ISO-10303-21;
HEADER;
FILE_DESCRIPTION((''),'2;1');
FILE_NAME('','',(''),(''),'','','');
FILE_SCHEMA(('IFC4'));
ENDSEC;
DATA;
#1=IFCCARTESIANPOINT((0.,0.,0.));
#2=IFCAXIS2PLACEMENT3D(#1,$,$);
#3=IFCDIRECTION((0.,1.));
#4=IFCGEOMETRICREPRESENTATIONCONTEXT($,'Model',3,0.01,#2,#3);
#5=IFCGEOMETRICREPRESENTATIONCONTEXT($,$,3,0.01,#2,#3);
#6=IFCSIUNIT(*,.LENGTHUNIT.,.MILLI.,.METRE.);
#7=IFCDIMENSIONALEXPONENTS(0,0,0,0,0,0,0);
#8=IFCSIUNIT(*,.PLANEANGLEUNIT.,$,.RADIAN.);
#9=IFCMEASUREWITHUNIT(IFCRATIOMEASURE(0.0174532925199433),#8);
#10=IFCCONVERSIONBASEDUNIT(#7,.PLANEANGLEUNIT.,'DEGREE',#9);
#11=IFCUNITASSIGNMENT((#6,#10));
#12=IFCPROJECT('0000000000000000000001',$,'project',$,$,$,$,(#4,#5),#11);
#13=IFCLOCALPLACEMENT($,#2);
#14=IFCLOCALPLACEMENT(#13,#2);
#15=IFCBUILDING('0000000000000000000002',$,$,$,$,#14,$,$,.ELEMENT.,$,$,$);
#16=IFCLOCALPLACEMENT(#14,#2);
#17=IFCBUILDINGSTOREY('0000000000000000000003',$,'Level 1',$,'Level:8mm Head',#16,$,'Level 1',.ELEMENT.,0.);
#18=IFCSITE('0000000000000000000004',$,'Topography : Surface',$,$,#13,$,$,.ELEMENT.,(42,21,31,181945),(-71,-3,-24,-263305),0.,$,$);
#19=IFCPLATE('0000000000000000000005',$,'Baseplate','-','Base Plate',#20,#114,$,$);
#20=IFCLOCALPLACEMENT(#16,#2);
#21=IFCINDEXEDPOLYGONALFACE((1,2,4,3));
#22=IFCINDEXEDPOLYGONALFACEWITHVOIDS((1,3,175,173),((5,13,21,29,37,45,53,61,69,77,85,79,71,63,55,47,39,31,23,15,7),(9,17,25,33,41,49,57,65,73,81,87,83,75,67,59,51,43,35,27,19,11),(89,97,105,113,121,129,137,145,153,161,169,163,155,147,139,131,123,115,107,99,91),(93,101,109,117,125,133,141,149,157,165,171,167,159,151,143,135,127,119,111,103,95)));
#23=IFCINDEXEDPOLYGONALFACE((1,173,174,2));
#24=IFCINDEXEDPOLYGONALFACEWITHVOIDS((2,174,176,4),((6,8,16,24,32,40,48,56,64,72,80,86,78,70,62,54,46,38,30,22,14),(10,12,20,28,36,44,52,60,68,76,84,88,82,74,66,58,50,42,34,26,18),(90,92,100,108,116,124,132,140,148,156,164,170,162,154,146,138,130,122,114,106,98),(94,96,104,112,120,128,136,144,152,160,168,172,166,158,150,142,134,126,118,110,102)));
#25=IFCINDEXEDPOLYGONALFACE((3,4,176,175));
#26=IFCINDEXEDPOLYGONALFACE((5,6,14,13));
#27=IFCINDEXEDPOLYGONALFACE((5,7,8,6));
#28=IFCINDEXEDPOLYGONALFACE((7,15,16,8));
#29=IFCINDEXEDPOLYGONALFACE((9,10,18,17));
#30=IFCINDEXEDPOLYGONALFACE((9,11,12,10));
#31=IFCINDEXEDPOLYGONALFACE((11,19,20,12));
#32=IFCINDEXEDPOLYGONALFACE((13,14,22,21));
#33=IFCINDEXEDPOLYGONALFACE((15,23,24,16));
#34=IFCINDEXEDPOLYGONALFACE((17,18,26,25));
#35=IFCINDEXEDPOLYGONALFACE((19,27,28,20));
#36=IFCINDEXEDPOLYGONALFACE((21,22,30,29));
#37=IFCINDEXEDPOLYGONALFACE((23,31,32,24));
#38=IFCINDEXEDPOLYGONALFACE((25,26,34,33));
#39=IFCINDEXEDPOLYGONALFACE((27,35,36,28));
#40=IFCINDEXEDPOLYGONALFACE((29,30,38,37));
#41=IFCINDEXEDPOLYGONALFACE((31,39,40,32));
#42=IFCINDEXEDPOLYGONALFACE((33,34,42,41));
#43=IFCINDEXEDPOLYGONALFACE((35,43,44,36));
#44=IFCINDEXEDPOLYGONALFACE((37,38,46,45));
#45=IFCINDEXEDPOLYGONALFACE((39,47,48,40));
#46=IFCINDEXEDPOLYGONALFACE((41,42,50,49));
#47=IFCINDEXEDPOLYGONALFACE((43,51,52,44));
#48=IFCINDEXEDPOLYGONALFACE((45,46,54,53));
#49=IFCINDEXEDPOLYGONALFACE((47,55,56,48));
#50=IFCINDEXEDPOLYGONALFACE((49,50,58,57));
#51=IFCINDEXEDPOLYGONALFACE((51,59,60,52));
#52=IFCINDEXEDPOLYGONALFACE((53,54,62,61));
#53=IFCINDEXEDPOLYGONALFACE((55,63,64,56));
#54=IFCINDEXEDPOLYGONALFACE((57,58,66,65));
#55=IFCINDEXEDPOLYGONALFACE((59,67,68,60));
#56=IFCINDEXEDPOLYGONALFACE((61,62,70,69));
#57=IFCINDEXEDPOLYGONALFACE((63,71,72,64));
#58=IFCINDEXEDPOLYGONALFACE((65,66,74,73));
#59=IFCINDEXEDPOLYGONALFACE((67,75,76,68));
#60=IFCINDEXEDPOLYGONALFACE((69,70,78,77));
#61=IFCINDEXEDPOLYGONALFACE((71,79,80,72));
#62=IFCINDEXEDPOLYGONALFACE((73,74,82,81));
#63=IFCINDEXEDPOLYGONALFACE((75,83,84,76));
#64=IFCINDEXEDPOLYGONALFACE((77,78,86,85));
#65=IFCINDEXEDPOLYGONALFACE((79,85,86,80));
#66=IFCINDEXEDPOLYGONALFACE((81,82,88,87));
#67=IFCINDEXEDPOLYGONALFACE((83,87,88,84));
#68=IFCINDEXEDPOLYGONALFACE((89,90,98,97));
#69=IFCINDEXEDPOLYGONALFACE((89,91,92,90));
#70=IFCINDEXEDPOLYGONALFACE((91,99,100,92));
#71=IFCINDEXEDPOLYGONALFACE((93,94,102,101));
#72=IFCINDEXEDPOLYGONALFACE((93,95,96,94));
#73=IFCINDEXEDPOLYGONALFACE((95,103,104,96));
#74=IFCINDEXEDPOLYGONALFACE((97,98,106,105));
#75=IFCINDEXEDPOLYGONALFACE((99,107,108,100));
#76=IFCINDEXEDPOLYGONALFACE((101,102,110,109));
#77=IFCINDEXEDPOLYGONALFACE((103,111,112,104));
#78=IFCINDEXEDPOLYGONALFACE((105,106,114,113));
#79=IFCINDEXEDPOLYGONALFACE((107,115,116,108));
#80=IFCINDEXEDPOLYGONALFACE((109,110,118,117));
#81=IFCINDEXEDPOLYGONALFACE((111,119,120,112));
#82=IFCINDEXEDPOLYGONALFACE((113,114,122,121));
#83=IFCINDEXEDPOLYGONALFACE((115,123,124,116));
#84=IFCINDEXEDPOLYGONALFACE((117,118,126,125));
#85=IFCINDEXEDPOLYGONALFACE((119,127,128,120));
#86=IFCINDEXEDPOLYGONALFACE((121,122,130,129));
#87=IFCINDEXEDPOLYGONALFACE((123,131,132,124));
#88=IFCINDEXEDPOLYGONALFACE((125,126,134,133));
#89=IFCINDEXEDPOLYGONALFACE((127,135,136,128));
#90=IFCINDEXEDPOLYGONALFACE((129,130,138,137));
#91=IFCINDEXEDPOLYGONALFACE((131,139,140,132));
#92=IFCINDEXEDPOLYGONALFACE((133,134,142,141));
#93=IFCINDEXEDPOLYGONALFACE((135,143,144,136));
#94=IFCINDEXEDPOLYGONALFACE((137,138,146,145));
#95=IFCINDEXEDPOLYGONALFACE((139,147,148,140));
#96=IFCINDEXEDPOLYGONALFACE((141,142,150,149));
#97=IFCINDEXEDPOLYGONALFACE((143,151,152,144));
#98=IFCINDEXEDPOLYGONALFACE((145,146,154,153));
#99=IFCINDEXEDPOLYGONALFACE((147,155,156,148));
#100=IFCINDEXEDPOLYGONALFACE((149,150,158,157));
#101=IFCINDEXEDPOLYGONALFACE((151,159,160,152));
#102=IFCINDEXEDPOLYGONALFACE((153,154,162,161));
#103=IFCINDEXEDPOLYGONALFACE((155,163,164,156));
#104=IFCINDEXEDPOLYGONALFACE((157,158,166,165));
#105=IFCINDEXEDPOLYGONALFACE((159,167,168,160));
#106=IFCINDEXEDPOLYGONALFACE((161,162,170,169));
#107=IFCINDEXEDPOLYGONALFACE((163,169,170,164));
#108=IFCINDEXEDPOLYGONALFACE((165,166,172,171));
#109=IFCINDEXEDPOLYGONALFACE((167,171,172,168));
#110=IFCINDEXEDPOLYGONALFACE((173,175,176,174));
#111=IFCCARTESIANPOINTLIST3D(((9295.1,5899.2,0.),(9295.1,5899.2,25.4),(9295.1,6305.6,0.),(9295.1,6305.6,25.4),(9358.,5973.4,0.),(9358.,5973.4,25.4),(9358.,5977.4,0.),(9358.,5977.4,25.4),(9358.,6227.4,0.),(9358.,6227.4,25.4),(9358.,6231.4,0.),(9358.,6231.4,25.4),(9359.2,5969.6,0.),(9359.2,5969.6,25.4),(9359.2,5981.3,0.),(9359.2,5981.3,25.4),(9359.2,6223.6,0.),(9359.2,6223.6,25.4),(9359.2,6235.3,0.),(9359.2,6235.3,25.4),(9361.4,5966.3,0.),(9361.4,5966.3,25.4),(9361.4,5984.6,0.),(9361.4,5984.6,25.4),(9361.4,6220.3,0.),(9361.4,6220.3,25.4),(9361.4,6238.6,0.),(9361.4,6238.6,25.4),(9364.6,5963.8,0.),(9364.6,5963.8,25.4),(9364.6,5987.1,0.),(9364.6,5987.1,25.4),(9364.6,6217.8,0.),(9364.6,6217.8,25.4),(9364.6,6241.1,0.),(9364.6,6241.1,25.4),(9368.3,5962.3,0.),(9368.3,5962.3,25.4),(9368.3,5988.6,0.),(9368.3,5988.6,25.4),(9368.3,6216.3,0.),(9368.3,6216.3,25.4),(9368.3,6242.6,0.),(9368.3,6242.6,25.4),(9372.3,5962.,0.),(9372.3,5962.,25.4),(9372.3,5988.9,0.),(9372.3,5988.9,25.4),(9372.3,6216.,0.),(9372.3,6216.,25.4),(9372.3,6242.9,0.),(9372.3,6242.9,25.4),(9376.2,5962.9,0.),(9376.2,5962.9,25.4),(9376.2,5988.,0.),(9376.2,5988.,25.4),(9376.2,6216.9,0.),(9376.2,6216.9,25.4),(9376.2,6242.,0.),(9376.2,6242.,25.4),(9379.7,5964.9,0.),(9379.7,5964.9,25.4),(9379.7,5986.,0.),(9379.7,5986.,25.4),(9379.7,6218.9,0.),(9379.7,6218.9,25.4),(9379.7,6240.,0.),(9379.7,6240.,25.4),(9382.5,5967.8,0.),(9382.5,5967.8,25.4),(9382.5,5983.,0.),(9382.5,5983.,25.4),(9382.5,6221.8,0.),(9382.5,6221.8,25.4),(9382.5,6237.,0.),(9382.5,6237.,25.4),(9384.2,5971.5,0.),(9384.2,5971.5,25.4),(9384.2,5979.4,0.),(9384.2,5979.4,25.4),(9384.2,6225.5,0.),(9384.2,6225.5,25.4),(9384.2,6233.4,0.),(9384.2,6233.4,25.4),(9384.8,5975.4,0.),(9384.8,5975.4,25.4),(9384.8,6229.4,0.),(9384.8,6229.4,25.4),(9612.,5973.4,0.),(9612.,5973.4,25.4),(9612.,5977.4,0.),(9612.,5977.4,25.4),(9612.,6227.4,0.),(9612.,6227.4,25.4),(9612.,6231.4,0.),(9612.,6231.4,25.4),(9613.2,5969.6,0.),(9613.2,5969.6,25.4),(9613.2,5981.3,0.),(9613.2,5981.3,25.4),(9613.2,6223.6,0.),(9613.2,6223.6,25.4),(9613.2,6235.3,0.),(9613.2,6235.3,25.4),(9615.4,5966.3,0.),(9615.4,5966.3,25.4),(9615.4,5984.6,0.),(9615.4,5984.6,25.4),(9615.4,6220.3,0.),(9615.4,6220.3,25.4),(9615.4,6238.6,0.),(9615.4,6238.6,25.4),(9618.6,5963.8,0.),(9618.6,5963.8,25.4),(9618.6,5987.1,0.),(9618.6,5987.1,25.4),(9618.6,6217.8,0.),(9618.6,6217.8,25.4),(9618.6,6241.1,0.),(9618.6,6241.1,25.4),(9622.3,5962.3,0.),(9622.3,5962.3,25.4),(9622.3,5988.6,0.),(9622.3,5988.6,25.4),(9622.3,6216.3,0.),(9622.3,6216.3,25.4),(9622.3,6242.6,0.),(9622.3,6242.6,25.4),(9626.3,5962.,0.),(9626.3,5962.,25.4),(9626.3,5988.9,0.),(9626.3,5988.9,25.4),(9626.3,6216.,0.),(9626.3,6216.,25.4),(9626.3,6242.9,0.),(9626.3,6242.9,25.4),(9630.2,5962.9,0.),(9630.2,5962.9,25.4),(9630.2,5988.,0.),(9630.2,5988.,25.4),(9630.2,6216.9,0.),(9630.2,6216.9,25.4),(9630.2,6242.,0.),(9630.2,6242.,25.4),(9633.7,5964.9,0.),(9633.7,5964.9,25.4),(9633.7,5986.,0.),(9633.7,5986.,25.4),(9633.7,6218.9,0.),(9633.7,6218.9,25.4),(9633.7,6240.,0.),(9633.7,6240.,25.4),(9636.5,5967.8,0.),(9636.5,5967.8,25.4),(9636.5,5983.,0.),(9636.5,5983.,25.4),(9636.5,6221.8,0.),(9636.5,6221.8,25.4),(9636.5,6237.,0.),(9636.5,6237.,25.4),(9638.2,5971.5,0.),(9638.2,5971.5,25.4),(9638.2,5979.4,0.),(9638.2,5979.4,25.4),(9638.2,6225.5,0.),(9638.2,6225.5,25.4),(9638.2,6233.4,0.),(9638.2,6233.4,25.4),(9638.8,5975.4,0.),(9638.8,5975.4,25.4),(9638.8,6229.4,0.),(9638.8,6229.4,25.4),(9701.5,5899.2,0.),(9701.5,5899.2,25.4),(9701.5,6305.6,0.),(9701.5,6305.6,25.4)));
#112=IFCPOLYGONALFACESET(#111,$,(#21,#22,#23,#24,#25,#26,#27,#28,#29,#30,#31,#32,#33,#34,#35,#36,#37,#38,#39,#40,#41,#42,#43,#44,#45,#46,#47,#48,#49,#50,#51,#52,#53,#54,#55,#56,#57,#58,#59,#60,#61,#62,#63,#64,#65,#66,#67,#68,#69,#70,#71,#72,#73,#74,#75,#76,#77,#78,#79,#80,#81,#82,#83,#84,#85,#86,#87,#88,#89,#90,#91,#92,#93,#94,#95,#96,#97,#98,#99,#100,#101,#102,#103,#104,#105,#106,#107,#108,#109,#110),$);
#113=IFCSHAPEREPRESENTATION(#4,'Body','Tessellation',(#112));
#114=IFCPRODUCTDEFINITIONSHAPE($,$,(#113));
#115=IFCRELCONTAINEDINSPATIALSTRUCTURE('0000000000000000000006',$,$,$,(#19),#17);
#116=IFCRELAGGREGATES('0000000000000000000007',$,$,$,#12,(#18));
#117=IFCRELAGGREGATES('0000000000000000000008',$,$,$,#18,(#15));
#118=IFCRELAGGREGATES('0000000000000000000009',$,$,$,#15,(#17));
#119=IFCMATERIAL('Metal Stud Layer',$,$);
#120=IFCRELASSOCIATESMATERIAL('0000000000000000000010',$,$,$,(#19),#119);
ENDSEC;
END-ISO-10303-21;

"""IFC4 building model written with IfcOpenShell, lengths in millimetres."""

from ifc_helpers import new_model, entity, si_unit, converted_unit, direction, frame, frame_2d, origin, origin_with_axes, place, context, project, spatial, polyline, circle, outline, extrude, material, element, save


model = new_model("IFC4")

# Units and contexts
model_context = context("Model", 3, precision=0.01, world=origin(), true_north=direction((0.0, 1.0)))
context_of_model = context(None, 3, precision=0.01, world=origin(), true_north=direction((0.0, 1.0)))
ifc_project = project(units=[si_unit("LENGTHUNIT", "METRE", prefix="MILLI"), converted_unit("PLANEANGLEUNIT", "DEGREE", entity("IfcRatioMeasure", 0.0174532925199433), si_unit("PLANEANGLEUNIT", "RADIAN"), dimensions=[0, 0, 0, 0, 0, 0, 0])], contexts=[model_context, context_of_model])

# Site, building, storey
site_placement = place(None, origin())
site = spatial("IfcSite", under=ifc_project, at=site_placement, Name="Topography : Surface", CompositionType="ELEMENT", RefLatitude=(42, 21, 31, 181945), RefLongitude=(-71, -3, -24, -263305), RefElevation=0.0)
building_placement = place(site_placement, origin())
building = spatial("IfcBuilding", under=site, at=building_placement, CompositionType="ELEMENT")
storey_placement = place(building_placement, origin())
storey = spatial("IfcBuildingStorey", under=building, at=storey_placement, Name="Level 1", ObjectType="Level:8mm Head", LongName="Level 1", CompositionType="ELEMENT", Elevation=0.0)

# Plate, openings
ifc_material_1 = material(Name="Metal Stud Layer")
plate_1_placement = place(storey_placement, frame((9295.1, 6305.6, 25.4), z_axis=(0.0, 0.0, -1.0), x_axis=(1.0, 0.0, 0.0)))
plate_1 = element("IfcPlate", 1, at=plate_1_placement, inside=storey, material=ifc_material_1, Name="Baseplate", Description="-", ObjectType="Base Plate", context=model_context, shape_type="SweptSolid", body=[
    extrude(outline(polyline([(0.0, 0.0), (406.4, 0.0), (406.4, 406.4), (0.0, 406.4), (0.0, 0.0)])), origin_with_axes(), (0.0, 0.0, 1.0), 25.4),
])
opening_1_placement = place(plate_1_placement, frame((203.2, 203.2, 25.9), z_axis=(0.0, 0.0, -1.0), x_axis=(1.0, 0.0, 0.0)))
element("IfcOpeningElement", 2, at=opening_1_placement, cuts=plate_1, ObjectType="Opening", context=model_context, shape_type="SweptSolid", body=[
    extrude(circle(Radius=13.5, at=frame_2d((127.0, 127.0), x_axis=(1.0, 0.0))), origin(), (0.0, 0.0, 1.0), 26.4),
])
opening_2_placement = place(plate_1_placement, frame((203.2, 203.2, 25.9), z_axis=(0.0, 0.0, -1.0), x_axis=(1.0, 0.0, 0.0)))
element("IfcOpeningElement", 3, at=opening_2_placement, cuts=plate_1, ObjectType="Opening", context=model_context, shape_type="SweptSolid", body=[
    extrude(circle(Radius=13.5, at=frame_2d((-127.0, 127.0), x_axis=(1.0, 0.0))), origin(), (0.0, 0.0, 1.0), 26.4),
])
opening_3_placement = place(plate_1_placement, frame((203.2, 203.2, 25.9), z_axis=(0.0, 0.0, -1.0), x_axis=(1.0, 0.0, 0.0)))
element("IfcOpeningElement", 4, at=opening_3_placement, cuts=plate_1, ObjectType="Opening", context=model_context, shape_type="SweptSolid", body=[
    extrude(circle(Radius=13.5, at=frame_2d((127.0, -127.0), x_axis=(1.0, 0.0))), origin(), (0.0, 0.0, 1.0), 26.4),
])
opening_4_placement = place(plate_1_placement, frame((203.2, 203.2, 25.9), z_axis=(0.0, 0.0, -1.0), x_axis=(1.0, 0.0, 0.0)))
element("IfcOpeningElement", 5, at=opening_4_placement, cuts=plate_1, ObjectType="Opening", context=model_context, shape_type="SweptSolid", body=[
    extrude(circle(Radius=13.5, at=frame_2d((-127.0, -127.0), x_axis=(1.0, 0.0))), origin(), (0.0, 0.0, 1.0), 26.4),
])

save(model, "model.ifc")
